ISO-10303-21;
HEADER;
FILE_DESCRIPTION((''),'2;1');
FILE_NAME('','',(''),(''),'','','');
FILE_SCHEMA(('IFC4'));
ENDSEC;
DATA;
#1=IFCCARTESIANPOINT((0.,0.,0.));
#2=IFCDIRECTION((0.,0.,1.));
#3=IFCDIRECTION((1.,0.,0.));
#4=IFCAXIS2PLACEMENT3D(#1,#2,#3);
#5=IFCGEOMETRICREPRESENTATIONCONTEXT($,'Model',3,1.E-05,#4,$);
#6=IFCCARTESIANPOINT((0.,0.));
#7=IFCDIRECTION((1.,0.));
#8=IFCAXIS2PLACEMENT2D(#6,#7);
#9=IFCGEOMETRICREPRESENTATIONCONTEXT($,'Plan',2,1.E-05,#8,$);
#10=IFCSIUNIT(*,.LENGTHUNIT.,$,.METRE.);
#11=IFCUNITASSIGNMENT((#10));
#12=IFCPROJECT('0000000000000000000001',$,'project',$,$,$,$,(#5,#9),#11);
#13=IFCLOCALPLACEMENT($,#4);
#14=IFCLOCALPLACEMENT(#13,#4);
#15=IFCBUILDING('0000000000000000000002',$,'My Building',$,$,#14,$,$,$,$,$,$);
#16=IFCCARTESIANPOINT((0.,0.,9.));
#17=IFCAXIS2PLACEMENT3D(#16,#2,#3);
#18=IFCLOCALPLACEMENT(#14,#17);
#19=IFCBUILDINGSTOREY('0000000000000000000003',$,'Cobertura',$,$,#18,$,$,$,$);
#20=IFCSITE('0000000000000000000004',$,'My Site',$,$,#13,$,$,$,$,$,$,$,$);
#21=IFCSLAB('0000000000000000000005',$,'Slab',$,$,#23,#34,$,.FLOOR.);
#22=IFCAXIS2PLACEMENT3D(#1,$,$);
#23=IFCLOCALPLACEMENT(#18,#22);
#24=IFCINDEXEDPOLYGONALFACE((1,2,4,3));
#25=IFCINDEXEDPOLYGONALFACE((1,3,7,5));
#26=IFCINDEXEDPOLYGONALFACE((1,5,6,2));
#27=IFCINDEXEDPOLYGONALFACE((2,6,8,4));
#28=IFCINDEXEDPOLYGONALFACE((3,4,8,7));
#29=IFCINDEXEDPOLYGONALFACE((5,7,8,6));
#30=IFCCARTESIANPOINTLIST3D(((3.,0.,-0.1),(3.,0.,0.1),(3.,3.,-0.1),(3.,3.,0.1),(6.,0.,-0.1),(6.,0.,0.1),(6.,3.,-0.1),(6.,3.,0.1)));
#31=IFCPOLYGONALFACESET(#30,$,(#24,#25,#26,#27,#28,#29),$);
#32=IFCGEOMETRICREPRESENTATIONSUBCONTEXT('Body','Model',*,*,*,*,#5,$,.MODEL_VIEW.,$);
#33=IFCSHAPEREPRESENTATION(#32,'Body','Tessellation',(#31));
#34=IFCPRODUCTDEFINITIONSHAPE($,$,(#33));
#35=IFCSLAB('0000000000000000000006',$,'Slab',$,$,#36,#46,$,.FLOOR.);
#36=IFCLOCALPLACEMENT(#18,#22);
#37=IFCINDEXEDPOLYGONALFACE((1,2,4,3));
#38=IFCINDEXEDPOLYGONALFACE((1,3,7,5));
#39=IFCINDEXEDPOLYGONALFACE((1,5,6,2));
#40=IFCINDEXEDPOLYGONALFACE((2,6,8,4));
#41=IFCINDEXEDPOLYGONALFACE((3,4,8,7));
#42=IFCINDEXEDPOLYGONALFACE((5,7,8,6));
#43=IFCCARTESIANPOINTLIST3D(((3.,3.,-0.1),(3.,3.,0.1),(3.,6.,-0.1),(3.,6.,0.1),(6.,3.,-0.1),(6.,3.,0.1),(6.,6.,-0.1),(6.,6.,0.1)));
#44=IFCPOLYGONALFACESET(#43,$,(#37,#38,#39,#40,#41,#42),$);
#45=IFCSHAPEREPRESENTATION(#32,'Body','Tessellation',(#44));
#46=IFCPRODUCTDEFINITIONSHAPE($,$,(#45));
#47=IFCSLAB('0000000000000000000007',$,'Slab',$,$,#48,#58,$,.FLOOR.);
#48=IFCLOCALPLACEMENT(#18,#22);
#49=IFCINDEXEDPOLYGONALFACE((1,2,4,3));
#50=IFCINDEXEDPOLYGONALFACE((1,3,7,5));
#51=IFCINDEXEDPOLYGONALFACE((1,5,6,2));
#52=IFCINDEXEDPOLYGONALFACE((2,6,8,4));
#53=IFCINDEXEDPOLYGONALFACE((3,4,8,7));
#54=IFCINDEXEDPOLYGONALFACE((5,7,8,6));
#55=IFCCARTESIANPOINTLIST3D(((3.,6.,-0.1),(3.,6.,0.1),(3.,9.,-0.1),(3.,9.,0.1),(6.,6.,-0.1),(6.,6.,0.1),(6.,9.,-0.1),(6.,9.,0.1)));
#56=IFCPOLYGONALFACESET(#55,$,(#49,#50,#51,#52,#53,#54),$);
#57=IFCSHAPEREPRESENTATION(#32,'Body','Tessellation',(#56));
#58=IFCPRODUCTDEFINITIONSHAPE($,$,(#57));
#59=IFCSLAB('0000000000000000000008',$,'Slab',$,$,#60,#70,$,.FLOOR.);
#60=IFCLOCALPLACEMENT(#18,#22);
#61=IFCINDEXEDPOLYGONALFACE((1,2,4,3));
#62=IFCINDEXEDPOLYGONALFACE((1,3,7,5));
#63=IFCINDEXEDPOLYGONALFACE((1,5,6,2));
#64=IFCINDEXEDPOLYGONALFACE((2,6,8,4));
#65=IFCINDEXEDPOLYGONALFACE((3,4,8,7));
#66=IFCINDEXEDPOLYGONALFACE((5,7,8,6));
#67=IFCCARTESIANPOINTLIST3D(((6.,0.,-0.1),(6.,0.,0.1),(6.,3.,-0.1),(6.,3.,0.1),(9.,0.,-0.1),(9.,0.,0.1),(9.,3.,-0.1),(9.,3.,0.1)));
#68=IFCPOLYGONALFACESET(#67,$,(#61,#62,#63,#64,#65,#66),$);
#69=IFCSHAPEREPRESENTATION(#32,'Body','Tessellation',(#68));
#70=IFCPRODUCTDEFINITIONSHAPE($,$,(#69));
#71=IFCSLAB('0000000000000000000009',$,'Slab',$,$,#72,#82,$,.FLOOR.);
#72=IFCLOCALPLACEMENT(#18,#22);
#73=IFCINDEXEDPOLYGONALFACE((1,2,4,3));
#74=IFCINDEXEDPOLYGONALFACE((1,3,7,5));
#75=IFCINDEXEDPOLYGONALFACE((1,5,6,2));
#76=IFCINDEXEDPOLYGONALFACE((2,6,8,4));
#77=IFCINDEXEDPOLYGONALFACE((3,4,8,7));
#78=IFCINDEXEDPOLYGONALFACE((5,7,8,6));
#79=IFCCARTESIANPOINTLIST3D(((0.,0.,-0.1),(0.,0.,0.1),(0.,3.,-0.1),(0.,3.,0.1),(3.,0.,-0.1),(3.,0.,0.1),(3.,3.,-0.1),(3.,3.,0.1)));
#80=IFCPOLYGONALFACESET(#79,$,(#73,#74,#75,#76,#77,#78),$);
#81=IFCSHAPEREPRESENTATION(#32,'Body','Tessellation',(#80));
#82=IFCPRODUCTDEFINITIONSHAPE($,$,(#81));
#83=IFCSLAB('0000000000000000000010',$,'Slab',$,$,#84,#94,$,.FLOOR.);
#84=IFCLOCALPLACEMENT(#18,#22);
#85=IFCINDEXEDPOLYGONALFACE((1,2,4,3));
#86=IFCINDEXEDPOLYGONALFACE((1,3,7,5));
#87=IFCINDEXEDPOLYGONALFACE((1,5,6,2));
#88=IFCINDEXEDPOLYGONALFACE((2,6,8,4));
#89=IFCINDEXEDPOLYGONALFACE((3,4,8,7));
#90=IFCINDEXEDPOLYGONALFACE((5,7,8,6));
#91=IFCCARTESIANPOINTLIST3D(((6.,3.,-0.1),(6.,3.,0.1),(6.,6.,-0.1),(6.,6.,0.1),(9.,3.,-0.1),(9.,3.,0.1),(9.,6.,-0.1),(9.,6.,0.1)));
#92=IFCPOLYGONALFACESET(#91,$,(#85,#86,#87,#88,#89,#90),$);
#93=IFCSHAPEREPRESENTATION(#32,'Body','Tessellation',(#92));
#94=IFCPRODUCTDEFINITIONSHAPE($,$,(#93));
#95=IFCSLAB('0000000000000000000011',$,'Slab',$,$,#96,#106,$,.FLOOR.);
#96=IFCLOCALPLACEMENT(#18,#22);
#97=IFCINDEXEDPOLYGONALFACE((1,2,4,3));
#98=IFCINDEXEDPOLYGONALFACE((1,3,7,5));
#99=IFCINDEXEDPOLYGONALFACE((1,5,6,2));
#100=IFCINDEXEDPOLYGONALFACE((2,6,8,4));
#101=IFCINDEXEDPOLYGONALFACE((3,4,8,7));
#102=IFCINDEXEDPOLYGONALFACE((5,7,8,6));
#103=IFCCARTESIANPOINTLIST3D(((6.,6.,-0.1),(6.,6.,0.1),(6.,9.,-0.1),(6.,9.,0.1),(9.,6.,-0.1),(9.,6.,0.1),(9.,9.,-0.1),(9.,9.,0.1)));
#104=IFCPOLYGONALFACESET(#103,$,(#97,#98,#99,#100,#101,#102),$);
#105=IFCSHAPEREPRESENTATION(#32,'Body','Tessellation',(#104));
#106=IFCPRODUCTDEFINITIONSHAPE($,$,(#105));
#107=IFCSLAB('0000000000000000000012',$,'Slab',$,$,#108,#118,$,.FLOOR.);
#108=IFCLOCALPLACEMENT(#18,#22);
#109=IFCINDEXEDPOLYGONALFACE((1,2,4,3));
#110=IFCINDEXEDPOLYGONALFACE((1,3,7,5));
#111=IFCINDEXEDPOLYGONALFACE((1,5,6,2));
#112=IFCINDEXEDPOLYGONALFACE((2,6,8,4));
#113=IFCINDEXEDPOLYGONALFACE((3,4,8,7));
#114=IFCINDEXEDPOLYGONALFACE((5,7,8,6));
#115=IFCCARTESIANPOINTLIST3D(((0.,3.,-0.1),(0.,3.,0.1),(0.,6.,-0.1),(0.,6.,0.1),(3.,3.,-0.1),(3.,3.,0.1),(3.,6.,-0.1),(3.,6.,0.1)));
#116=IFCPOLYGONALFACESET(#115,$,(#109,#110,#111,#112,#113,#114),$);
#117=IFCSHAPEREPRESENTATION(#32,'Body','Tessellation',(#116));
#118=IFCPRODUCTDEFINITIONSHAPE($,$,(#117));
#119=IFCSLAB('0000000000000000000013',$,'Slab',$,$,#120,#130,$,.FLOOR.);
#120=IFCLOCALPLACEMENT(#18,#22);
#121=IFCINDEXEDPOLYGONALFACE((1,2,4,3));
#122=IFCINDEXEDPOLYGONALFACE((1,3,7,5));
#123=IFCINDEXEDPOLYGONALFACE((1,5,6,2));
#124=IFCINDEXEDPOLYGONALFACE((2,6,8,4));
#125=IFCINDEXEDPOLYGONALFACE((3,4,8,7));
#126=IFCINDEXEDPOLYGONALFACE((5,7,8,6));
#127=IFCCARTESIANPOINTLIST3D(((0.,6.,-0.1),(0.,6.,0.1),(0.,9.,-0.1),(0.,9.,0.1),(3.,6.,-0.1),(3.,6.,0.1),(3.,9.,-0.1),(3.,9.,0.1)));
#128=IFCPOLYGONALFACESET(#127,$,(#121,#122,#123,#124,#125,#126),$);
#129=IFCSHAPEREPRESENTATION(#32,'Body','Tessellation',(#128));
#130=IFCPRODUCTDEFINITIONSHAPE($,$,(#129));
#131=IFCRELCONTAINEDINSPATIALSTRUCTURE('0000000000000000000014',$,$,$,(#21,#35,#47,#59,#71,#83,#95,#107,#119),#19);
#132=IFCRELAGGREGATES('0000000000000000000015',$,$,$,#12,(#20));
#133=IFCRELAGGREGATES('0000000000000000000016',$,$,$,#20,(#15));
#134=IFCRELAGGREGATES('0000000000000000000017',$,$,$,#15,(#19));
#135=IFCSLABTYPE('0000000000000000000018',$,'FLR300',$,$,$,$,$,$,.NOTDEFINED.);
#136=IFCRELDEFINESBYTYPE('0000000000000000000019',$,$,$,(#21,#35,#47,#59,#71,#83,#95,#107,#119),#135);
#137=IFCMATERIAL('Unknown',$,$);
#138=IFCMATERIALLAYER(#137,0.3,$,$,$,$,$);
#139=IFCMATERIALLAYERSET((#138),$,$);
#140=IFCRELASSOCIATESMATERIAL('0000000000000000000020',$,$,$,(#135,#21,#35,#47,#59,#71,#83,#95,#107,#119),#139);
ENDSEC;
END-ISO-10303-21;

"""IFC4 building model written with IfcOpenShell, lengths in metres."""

from ifc_helpers import new_model, si_unit, frame, origin, origin_with_axes, origin_2d_with_axis, place, context, subcontext, project, spatial, polyline, outline, extrude, material, layer, layer_set, layer_usage, type_object, element, save


model = new_model("IFC4")

# Units and contexts
model_context = context("Model", 3, precision=1e-05, world=origin_with_axes())
plan_context = context("Plan", 2, precision=1e-05, world=origin_2d_with_axis())
body_context = subcontext(model_context, "Body", "Model", "MODEL_VIEW")
ifc_project = project(units=[si_unit("LENGTHUNIT", "METRE")], contexts=[model_context, plan_context])

# Site, building, storey
site_placement = place(None, origin_with_axes())
site = spatial("IfcSite", under=ifc_project, at=site_placement, Name="My Site")
building_placement = place(site_placement, origin_with_axes())
building = spatial("IfcBuilding", under=site, at=building_placement, Name="My Building")
storey_placement = place(building_placement, frame((0.0, 0.0, 9.0), z_axis=(0.0, 0.0, 1.0), x_axis=(1.0, 0.0, 0.0)))
storey = spatial("IfcBuildingStorey", under=building, at=storey_placement, Name="Cobertura")

# Slabs
ifc_material = material(Name="Unknown")
ifc_layer = layer(ifc_material, 0.3)
ifc_layer_set = layer_set([ifc_layer])
ifc_layer_usage_1 = layer_usage(ifc_layer_set, "AXIS3", "POSITIVE", 0.0)
slab_type = type_object("IfcSlabType", Name="FLR300", PredefinedType="NOTDEFINED", material=ifc_layer_set)
slab_1_placement = place(storey_placement, frame((4.5, 1.5, -0.1), z_axis=(0.0, 0.0, 1.0), x_axis=(1.0, 0.0, 0.0)))
element("IfcSlab", 1, at=slab_1_placement, inside=storey, type_object=slab_type, material=ifc_layer_usage_1, Name="Slab", PredefinedType="FLOOR", context=body_context, shape_type="SweptSolid", body=[
    extrude(outline(polyline([(1.5, 1.5), (-1.5, 1.5), (-1.5, -1.5), (1.5, -1.5), (1.5, 1.5)])), origin(), (0.0, 0.0, 1.0), 0.2),
])
ifc_layer_usage_2 = layer_usage(ifc_layer_set, "AXIS3", "POSITIVE", 0.0)
slab_2_placement = place(storey_placement, frame((4.5, 4.5, -0.1), z_axis=(0.0, 0.0, 1.0), x_axis=(1.0, 0.0, 0.0)))
element("IfcSlab", 2, at=slab_2_placement, inside=storey, type_object=slab_type, material=ifc_layer_usage_2, Name="Slab", PredefinedType="FLOOR", context=body_context, shape_type="SweptSolid", body=[
    extrude(outline(polyline([(1.5, 1.5), (-1.5, 1.5), (-1.5, -1.5), (1.5, -1.5), (1.5, 1.5)])), origin(), (0.0, 0.0, 1.0), 0.2),
])
ifc_layer_usage_3 = layer_usage(ifc_layer_set, "AXIS3", "POSITIVE", 0.0)
slab_3_placement = place(storey_placement, frame((4.5, 7.5, -0.1), z_axis=(0.0, 0.0, 1.0), x_axis=(1.0, 0.0, 0.0)))
element("IfcSlab", 3, at=slab_3_placement, inside=storey, type_object=slab_type, material=ifc_layer_usage_3, Name="Slab", PredefinedType="FLOOR", context=body_context, shape_type="SweptSolid", body=[
    extrude(outline(polyline([(1.5, 1.5), (-1.5, 1.5), (-1.5, -1.5), (1.5, -1.5), (1.5, 1.5)])), origin(), (0.0, 0.0, 1.0), 0.2),
])
ifc_layer_usage_4 = layer_usage(ifc_layer_set, "AXIS3", "POSITIVE", 0.0)
slab_4_placement = place(storey_placement, frame((7.5, 1.5, -0.1), z_axis=(0.0, 0.0, 1.0), x_axis=(1.0, 0.0, 0.0)))
element("IfcSlab", 4, at=slab_4_placement, inside=storey, type_object=slab_type, material=ifc_layer_usage_4, Name="Slab", PredefinedType="FLOOR", context=body_context, shape_type="SweptSolid", body=[
    extrude(outline(polyline([(1.5, 1.5), (-1.5, 1.5), (-1.5, -1.5), (1.5, -1.5), (1.5, 1.5)])), origin(), (0.0, 0.0, 1.0), 0.2),
])
ifc_layer_usage_5 = layer_usage(ifc_layer_set, "AXIS3", "POSITIVE", 0.0)
slab_5_placement = place(storey_placement, frame((1.5, 1.5, -0.1), z_axis=(0.0, 0.0, 1.0), x_axis=(1.0, 0.0, 0.0)))
element("IfcSlab", 5, at=slab_5_placement, inside=storey, type_object=slab_type, material=ifc_layer_usage_5, Name="Slab", PredefinedType="FLOOR", context=body_context, shape_type="SweptSolid", body=[
    extrude(outline(polyline([(1.5, 1.5), (-1.5, 1.5), (-1.5, -1.5), (1.5, -1.5), (1.5, 1.5)])), origin(), (0.0, 0.0, 1.0), 0.2),
])
ifc_layer_usage_6 = layer_usage(ifc_layer_set, "AXIS3", "POSITIVE", 0.0)
slab_6_placement = place(storey_placement, frame((7.5, 4.5, -0.1), z_axis=(0.0, 0.0, 1.0), x_axis=(1.0, 0.0, 0.0)))
element("IfcSlab", 6, at=slab_6_placement, inside=storey, type_object=slab_type, material=ifc_layer_usage_6, Name="Slab", PredefinedType="FLOOR", context=body_context, shape_type="SweptSolid", body=[
    extrude(outline(polyline([(1.5, 1.5), (-1.5, 1.5), (-1.5, -1.5), (1.5, -1.5), (1.5, 1.5)])), origin(), (0.0, 0.0, 1.0), 0.2),
])
ifc_layer_usage_7 = layer_usage(ifc_layer_set, "AXIS3", "POSITIVE", 0.0)
slab_7_placement = place(storey_placement, frame((7.5, 7.5, -0.1), z_axis=(0.0, 0.0, 1.0), x_axis=(1.0, 0.0, 0.0)))
element("IfcSlab", 7, at=slab_7_placement, inside=storey, type_object=slab_type, material=ifc_layer_usage_7, Name="Slab", PredefinedType="FLOOR", context=body_context, shape_type="SweptSolid", body=[
    extrude(outline(polyline([(1.5, 1.5), (-1.5, 1.5), (-1.5, -1.5), (1.5, -1.5), (1.5, 1.5)])), origin(), (0.0, 0.0, 1.0), 0.2),
])
ifc_layer_usage_8 = layer_usage(ifc_layer_set, "AXIS3", "POSITIVE", 0.0)
slab_8_placement = place(storey_placement, frame((1.5, 4.5, -0.1), z_axis=(0.0, 0.0, 1.0), x_axis=(1.0, 0.0, 0.0)))
element("IfcSlab", 8, at=slab_8_placement, inside=storey, type_object=slab_type, material=ifc_layer_usage_8, Name="Slab", PredefinedType="FLOOR", context=body_context, shape_type="SweptSolid", body=[
    extrude(outline(polyline([(1.5, 1.5), (-1.5, 1.5), (-1.5, -1.5), (1.5, -1.5), (1.5, 1.5)])), origin(), (0.0, 0.0, 1.0), 0.2),
])
ifc_layer_usage_9 = layer_usage(ifc_layer_set, "AXIS3", "POSITIVE", 0.0)
slab_9_placement = place(storey_placement, frame((1.5, 7.5, -0.1), z_axis=(0.0, 0.0, 1.0), x_axis=(1.0, 0.0, 0.0)))
element("IfcSlab", 9, at=slab_9_placement, inside=storey, type_object=slab_type, material=ifc_layer_usage_9, Name="Slab", PredefinedType="FLOOR", context=body_context, shape_type="SweptSolid", body=[
    extrude(outline(polyline([(1.5, 1.5), (-1.5, 1.5), (-1.5, -1.5), (1.5, -1.5), (1.5, 1.5)])), origin(), (0.0, 0.0, 1.0), 0.2),
])

save(model, "model.ifc")
